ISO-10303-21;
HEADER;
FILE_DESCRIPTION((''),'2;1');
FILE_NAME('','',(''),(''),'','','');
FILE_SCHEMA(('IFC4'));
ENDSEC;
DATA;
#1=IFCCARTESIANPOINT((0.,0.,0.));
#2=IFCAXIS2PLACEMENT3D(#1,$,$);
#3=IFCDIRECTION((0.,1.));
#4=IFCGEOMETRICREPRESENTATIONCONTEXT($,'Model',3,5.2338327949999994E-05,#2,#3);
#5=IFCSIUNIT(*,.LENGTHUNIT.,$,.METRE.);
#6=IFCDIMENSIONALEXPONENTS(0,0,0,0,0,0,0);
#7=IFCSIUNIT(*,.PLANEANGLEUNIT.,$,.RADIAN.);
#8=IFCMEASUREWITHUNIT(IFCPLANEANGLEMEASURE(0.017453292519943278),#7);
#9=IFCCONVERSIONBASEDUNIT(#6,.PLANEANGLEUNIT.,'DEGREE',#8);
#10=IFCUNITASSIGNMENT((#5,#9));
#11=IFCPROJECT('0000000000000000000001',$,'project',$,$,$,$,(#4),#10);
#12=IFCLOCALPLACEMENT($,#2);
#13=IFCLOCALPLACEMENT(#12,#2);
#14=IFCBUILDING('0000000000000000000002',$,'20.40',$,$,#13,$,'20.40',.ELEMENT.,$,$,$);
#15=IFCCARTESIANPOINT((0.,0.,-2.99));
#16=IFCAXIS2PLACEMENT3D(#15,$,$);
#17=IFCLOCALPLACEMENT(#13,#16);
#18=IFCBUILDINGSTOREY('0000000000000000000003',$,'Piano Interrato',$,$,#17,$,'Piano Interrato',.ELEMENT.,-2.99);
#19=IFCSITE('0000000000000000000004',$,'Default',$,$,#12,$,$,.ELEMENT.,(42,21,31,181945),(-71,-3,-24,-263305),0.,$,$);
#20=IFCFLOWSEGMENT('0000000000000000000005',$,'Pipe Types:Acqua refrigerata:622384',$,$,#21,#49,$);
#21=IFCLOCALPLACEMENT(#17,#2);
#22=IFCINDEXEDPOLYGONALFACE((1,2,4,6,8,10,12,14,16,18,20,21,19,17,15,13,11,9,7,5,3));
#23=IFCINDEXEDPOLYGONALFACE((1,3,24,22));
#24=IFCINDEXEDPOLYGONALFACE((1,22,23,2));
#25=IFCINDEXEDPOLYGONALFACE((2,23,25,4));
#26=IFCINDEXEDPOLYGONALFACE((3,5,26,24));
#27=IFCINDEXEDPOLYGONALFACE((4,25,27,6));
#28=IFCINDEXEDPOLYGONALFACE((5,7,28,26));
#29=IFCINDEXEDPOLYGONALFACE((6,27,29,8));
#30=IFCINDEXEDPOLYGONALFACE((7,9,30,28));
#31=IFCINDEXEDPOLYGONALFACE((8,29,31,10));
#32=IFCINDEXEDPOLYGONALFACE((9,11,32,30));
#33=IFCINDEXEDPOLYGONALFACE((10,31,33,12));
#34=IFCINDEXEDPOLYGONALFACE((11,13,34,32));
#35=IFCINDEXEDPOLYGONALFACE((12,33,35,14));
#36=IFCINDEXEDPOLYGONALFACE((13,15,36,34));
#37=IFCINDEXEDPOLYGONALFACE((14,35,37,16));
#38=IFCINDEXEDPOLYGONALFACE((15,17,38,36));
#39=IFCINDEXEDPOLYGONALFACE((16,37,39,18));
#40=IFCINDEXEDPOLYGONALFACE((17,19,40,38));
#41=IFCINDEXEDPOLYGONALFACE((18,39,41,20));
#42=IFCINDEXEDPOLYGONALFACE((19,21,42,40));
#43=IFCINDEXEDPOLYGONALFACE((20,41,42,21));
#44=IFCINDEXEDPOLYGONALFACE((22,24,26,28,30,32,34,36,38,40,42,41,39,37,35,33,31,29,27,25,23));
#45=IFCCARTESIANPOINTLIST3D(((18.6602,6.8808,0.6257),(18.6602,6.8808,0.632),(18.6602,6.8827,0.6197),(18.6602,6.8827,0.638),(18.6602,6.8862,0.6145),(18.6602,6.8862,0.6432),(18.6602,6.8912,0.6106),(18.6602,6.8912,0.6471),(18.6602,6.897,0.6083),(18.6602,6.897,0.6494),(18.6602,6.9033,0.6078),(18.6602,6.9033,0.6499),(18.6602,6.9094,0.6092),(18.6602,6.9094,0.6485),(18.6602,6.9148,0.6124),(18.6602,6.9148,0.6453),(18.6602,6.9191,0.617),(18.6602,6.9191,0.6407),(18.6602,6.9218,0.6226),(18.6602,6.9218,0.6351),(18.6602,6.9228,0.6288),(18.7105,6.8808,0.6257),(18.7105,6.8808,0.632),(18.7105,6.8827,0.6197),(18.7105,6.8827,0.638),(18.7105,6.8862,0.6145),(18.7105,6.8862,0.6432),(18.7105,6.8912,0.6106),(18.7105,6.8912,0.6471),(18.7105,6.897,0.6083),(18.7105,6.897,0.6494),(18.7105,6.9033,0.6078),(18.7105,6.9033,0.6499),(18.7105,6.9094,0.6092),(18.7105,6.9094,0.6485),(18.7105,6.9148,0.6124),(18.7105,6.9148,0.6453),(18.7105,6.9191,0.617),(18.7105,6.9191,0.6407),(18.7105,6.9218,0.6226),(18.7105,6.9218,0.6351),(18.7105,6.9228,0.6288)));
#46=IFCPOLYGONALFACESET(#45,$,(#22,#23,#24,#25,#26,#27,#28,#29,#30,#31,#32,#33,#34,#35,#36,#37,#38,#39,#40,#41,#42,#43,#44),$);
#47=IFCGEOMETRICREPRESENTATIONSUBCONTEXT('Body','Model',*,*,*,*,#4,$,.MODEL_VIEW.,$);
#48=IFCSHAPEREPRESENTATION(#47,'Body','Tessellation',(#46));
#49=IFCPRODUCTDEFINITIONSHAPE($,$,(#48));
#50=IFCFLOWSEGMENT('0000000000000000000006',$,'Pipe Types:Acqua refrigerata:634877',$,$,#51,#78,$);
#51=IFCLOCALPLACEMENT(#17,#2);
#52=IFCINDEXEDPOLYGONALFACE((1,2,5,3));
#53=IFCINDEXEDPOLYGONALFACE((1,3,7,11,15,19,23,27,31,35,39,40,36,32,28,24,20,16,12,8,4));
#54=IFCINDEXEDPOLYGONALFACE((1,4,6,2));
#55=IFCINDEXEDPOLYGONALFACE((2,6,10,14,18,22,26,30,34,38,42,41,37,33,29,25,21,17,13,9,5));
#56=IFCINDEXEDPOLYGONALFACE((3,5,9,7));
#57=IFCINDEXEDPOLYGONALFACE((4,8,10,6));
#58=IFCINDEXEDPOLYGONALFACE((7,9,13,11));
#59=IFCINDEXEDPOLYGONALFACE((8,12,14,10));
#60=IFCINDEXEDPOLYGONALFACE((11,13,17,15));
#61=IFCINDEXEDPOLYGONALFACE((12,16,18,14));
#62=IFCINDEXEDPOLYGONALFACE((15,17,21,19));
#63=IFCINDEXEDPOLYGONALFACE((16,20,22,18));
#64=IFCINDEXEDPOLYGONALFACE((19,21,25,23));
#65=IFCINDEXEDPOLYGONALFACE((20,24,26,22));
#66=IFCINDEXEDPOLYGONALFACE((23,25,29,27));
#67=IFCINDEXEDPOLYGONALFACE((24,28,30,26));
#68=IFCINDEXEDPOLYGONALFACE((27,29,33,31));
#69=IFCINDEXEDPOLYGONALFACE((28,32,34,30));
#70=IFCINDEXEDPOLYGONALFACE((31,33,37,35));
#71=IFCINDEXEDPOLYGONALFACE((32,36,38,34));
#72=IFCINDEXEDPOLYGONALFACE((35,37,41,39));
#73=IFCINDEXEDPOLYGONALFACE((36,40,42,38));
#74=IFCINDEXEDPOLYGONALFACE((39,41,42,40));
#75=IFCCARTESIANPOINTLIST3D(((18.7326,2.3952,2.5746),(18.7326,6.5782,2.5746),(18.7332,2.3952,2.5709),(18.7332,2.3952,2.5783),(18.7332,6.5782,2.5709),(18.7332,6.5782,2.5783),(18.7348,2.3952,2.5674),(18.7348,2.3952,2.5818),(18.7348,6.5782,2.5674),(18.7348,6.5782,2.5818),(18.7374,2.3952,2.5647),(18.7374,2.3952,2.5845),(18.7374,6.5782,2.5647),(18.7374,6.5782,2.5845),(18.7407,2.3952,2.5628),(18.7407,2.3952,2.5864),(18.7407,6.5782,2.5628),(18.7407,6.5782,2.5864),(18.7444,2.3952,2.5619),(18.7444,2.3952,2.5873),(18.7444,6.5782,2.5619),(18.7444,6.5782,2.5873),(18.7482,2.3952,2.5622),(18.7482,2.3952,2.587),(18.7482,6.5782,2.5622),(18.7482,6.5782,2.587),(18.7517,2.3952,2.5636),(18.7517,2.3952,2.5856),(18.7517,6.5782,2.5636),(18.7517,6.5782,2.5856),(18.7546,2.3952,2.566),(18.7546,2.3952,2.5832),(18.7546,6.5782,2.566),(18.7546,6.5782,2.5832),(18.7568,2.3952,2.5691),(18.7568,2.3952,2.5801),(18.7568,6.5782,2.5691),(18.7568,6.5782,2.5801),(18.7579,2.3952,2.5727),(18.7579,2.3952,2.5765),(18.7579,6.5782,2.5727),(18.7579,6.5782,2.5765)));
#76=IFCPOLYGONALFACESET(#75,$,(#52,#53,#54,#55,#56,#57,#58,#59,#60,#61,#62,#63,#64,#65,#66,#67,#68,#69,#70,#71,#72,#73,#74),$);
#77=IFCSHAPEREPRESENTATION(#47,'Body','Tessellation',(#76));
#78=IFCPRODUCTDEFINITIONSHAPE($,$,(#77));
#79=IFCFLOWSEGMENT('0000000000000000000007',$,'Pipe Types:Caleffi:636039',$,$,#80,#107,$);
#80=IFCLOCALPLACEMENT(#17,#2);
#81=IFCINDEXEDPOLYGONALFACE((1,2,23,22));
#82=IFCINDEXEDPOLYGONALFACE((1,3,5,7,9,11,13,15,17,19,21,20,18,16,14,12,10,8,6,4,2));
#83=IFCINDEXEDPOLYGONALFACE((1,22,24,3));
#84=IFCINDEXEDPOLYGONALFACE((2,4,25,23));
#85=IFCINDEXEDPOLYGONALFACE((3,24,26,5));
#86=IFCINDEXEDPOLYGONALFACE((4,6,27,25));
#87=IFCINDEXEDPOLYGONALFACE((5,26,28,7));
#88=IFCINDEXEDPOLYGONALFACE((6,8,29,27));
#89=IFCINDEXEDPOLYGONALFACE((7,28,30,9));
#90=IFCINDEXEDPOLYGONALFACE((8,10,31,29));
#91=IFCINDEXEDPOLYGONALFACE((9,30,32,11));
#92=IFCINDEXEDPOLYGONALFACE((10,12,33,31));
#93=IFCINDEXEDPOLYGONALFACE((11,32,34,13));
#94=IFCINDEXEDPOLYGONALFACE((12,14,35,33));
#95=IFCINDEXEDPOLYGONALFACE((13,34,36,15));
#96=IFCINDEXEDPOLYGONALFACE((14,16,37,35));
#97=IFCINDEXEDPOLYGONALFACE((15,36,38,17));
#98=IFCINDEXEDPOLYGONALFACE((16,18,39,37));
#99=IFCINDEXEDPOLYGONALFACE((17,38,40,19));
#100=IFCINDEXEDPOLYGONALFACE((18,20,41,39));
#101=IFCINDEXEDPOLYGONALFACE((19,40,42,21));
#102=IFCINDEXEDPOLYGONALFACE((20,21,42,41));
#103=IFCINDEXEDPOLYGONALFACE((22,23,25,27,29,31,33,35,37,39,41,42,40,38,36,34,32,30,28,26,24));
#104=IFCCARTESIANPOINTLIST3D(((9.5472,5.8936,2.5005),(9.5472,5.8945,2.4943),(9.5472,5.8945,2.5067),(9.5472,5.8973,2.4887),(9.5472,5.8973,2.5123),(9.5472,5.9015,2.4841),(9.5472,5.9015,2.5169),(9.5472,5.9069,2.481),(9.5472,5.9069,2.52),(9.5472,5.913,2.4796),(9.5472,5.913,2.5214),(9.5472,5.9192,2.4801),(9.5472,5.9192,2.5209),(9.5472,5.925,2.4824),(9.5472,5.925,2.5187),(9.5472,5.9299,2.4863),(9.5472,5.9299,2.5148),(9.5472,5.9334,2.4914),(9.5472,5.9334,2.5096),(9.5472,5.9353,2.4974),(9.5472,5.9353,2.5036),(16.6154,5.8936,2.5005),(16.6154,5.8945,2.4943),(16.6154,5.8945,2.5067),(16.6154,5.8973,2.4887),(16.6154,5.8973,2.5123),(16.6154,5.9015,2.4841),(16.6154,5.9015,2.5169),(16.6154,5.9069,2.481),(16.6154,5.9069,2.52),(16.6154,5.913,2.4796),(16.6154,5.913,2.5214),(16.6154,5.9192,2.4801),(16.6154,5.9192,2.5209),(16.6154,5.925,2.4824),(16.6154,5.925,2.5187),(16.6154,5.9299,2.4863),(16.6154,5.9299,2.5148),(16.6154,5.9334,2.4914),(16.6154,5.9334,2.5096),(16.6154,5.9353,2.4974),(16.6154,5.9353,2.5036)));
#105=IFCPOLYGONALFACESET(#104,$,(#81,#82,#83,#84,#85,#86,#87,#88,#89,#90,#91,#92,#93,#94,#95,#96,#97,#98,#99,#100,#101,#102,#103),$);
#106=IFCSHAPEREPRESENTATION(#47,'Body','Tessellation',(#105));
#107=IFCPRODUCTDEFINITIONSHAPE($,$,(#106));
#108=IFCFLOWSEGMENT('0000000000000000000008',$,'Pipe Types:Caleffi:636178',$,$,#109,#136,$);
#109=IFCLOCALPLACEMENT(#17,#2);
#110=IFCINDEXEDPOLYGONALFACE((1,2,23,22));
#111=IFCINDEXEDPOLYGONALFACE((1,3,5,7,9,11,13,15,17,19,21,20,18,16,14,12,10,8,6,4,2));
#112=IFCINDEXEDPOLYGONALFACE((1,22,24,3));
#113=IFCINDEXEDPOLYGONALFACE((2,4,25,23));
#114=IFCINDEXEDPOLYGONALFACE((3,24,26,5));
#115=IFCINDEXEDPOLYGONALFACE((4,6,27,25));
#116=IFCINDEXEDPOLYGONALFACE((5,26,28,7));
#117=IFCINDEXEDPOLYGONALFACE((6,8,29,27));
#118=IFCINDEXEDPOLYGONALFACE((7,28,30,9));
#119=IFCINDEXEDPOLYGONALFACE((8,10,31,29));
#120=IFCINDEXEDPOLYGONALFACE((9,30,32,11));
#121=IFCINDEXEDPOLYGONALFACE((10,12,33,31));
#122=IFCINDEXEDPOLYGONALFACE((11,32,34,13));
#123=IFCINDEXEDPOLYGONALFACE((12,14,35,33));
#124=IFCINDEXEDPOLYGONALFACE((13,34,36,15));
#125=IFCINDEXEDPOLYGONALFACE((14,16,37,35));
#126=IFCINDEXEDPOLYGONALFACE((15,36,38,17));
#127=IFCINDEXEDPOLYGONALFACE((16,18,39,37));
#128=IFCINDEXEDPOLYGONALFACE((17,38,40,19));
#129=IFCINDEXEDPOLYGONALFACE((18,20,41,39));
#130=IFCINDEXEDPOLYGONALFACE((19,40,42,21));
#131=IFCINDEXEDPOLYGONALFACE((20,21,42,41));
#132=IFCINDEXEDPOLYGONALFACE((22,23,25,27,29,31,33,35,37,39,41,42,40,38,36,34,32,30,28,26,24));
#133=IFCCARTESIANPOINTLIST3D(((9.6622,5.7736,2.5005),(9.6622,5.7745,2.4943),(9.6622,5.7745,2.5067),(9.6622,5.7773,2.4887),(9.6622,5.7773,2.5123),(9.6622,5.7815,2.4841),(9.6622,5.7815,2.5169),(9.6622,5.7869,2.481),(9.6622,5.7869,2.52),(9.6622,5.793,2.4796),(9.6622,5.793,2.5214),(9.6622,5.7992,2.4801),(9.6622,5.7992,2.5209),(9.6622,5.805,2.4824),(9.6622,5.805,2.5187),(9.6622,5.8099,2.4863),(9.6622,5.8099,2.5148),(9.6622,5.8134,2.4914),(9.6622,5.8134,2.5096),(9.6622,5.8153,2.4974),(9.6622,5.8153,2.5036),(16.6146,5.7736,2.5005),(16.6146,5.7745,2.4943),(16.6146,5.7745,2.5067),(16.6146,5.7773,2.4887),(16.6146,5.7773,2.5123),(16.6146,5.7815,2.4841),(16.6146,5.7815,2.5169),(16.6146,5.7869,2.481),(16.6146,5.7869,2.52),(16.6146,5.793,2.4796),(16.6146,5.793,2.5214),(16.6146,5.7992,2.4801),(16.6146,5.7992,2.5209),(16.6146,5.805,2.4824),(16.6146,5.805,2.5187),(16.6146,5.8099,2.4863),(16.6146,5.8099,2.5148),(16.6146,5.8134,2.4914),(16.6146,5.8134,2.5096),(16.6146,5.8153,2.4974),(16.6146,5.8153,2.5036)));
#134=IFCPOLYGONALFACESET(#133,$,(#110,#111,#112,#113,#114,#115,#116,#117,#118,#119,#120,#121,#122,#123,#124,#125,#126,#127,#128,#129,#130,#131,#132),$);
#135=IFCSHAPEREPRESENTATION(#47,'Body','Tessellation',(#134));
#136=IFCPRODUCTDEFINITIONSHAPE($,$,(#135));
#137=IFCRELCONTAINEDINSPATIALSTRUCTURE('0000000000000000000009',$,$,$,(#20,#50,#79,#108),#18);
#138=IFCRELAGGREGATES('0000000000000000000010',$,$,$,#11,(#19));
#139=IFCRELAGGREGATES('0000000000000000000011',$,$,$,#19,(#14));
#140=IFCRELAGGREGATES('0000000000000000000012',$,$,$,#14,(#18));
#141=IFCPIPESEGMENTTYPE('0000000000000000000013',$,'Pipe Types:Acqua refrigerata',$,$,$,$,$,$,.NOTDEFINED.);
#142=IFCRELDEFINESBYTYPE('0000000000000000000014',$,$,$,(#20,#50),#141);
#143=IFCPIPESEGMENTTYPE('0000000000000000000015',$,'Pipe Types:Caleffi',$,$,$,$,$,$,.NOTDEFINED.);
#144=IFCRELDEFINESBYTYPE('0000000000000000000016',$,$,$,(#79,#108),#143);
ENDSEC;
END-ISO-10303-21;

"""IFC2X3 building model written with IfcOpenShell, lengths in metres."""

from ifc_helpers import new_model, entity, si_unit, converted_unit, direction, frame, frame_2d, origin, origin_2d_with_axis, place, context, subcontext, project, spatial, circle, extrude, type_object, element, save


model = new_model("IFC2X3")

# Units and contexts
model_context = context("Model", 3, precision=5.2338327949999994e-05, world=origin(), true_north=direction((0.0, 1.0)))
body_context = subcontext(model_context, "Body", "Model", "MODEL_VIEW")
ifc_project = project(units=[si_unit("LENGTHUNIT", "METRE"), converted_unit("PLANEANGLEUNIT", "DEGREE", entity("IfcPlaneAngleMeasure", 0.017453292519943278), si_unit("PLANEANGLEUNIT", "RADIAN"), dimensions=[0, 0, 0, 0, 0, 0, 0])], contexts=[model_context])

# Site, building, storey
site_placement = place(None, origin())
site = spatial("IfcSite", under=ifc_project, at=site_placement, Name="Default", CompositionType="ELEMENT", RefLatitude=(42, 21, 31, 181945), RefLongitude=(-71, -3, -24, -263305), RefElevation=0.0)
building_placement = place(site_placement, origin())
building = spatial("IfcBuilding", under=site, at=building_placement, Name="20.40", LongName="20.40", CompositionType="ELEMENT")
storey_placement = place(building_placement, frame((0.0, 0.0, -2.99)))
storey = spatial("IfcBuildingStorey", under=building, at=storey_placement, Name="Piano Interrato", LongName="Piano Interrato", CompositionType="ELEMENT", Elevation=-2.99)

# Flow segments
pipe_segment_type_1 = type_object("IfcPipeSegmentType", Name="Pipe Types:Acqua refrigerata", PredefinedType="NOTDEFINED")
flow_segment_1_placement = place(storey_placement, origin())
element("IfcFlowSegment", 1, at=flow_segment_1_placement, inside=storey, type_object=pipe_segment_type_1, Name="Pipe Types:Acqua refrigerata:622384", context=body_context, shape_type="SweptSolid", body=[
    extrude(circle(Radius=0.0211, at=frame_2d((0.0, 0.0), x_axis=(1.0, 0.0))), frame((18.6602, 6.9017, 0.6288), z_axis=(1.0, 0.0, 0.0), x_axis=(0.0, 1.0, 0.0)), (0.0, 0.0, 1.0), 0.0503),
])
flow_segment_2_placement = place(storey_placement, origin())
element("IfcFlowSegment", 2, at=flow_segment_2_placement, inside=storey, type_object=pipe_segment_type_1, Name="Pipe Types:Acqua refrigerata:634877", context=body_context, shape_type="SweptSolid", body=[
    extrude(circle(Radius=0.0127, at=origin_2d_with_axis()), frame((18.7453, 2.3952, 2.5746), z_axis=(0.0, 1.0, 0.0), x_axis=(-1.0, 0.0, 0.0)), (0.0, 0.0, 1.0), 4.183),
])
pipe_segment_type_2 = type_object("IfcPipeSegmentType", Name="Pipe Types:Caleffi", PredefinedType="NOTDEFINED")
flow_segment_3_placement = place(storey_placement, origin())
element("IfcFlowSegment", 3, at=flow_segment_3_placement, inside=storey, type_object=pipe_segment_type_2, Name="Pipe Types:Caleffi:636039", context=body_context, shape_type="SweptSolid", body=[
    extrude(circle(Radius=0.0209, at=origin_2d_with_axis()), frame((9.5472, 5.9146, 2.5005), z_axis=(1.0, 0.0, 0.0), x_axis=(0.0, -1.0, 0.0)), (0.0, 0.0, 1.0), 7.0681),
])
flow_segment_4_placement = place(storey_placement, origin())
element("IfcFlowSegment", 4, at=flow_segment_4_placement, inside=storey, type_object=pipe_segment_type_2, Name="Pipe Types:Caleffi:636178", context=body_context, shape_type="SweptSolid", body=[
    extrude(circle(Radius=0.0209, at=origin_2d_with_axis()), frame((9.6622, 5.7946, 2.5005), z_axis=(1.0, 0.0, 0.0), x_axis=(0.0, -1.0, 0.0)), (0.0, 0.0, 1.0), 6.9524),
])

save(model, "model.ifc")
